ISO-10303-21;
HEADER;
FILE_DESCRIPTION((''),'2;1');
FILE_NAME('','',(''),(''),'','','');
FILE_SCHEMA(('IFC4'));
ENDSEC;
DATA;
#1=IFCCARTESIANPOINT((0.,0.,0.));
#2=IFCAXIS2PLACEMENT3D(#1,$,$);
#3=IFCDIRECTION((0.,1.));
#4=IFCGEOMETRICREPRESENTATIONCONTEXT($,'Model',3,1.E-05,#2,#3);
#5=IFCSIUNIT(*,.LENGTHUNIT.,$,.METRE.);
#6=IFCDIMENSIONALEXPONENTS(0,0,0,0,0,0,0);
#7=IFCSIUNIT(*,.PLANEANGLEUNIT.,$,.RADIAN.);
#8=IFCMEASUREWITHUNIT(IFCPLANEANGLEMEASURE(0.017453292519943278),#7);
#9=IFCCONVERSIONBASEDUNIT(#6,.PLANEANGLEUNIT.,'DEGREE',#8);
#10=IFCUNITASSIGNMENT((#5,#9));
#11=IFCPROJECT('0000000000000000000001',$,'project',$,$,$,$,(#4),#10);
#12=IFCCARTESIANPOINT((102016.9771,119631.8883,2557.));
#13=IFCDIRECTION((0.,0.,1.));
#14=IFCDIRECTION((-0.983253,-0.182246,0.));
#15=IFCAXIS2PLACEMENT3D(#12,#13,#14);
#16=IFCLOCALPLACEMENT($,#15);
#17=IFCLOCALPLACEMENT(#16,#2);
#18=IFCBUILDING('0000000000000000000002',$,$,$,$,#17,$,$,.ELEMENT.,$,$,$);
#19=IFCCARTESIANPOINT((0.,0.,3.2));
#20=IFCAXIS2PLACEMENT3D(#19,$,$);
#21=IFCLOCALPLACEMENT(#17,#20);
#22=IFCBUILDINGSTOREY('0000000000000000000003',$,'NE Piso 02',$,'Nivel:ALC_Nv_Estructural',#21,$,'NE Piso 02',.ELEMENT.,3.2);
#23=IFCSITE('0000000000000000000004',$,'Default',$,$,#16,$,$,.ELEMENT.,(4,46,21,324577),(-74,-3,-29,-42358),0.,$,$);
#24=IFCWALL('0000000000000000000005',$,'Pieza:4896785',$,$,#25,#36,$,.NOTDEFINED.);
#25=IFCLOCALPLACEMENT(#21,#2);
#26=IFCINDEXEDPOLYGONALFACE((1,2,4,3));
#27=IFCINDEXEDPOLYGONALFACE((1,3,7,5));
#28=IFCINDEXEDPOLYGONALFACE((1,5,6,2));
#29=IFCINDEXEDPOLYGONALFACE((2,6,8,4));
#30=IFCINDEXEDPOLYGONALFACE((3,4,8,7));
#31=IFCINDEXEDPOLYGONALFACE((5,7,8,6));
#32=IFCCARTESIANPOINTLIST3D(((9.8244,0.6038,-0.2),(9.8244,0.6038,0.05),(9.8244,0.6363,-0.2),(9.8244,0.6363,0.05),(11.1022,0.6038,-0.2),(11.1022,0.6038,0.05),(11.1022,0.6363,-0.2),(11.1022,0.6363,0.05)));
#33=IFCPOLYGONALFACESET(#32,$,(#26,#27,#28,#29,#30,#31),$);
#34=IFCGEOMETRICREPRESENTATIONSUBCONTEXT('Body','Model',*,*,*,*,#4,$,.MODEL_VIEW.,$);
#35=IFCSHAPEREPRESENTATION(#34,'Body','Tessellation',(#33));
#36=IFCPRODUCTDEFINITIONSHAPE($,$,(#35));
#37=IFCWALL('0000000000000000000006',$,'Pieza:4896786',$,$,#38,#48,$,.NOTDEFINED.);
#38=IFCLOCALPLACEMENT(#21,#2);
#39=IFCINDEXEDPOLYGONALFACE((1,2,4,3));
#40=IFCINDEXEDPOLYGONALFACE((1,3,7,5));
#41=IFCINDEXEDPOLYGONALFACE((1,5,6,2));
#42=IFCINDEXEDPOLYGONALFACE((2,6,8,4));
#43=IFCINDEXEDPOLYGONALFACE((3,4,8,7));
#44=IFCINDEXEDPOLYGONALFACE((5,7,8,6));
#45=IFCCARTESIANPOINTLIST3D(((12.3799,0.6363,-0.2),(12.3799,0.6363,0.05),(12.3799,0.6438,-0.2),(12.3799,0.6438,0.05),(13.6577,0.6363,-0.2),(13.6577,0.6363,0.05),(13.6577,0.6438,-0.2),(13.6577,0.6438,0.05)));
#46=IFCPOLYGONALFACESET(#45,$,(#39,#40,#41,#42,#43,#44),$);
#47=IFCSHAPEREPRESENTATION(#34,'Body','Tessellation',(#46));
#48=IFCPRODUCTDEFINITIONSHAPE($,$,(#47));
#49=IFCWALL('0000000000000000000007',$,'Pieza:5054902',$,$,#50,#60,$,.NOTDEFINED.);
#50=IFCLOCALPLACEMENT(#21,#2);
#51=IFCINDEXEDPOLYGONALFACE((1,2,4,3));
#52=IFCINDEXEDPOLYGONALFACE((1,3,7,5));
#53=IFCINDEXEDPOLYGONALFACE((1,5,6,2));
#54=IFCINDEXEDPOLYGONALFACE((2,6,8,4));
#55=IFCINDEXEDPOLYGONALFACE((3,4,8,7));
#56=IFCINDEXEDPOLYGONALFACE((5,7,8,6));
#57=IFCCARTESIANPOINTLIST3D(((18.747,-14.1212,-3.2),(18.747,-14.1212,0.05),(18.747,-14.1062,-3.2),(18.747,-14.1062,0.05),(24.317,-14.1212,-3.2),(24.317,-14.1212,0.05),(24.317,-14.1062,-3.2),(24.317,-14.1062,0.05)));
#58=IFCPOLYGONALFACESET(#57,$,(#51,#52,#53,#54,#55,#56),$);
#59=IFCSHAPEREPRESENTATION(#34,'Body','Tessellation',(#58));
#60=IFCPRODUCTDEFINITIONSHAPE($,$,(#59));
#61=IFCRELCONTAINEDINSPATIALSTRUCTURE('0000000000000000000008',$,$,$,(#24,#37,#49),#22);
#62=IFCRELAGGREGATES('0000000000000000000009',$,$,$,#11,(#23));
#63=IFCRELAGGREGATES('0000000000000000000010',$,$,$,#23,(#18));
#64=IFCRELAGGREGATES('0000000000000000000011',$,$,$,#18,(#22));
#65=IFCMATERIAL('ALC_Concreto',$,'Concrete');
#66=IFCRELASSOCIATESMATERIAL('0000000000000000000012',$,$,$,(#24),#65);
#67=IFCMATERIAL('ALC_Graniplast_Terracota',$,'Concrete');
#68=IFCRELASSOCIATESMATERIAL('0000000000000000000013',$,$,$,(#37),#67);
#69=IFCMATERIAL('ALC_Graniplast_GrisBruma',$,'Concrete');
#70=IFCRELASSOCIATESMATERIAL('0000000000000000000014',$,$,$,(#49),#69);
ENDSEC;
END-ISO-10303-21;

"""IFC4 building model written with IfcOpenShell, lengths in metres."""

from ifc_helpers import new_model, entity, si_unit, converted_unit, direction, frame, frame_2d, origin, origin_2d_with_axis, place, context, subcontext, project, spatial, rectangle, extrude, material, element, save


model = new_model("IFC4")

# Units and contexts
model_context = context("Model", 3, precision=1e-05, world=origin(), true_north=direction((0.0, 1.0)))
body_context = subcontext(model_context, "Body", "Model", "MODEL_VIEW")
ifc_project = project(units=[si_unit("LENGTHUNIT", "METRE"), converted_unit("PLANEANGLEUNIT", "DEGREE", entity("IfcPlaneAngleMeasure", 0.017453292519943278), si_unit("PLANEANGLEUNIT", "RADIAN"), dimensions=[0, 0, 0, 0, 0, 0, 0])], contexts=[model_context])

# Site, building, storey
site_placement = place(None, frame((102016.9771, 119631.8883, 2557.0), z_axis=(0.0, 0.0, 1.0), x_axis=(-0.983253, -0.182246, 0.0)))
site = spatial("IfcSite", under=ifc_project, at=site_placement, Name="Default", CompositionType="ELEMENT", RefLatitude=(4, 46, 21, 324577), RefLongitude=(-74, -3, -29, -42358), RefElevation=0.0)
building_placement = place(site_placement, origin())
building = spatial("IfcBuilding", under=site, at=building_placement, CompositionType="ELEMENT")
storey_placement = place(building_placement, frame((0.0, 0.0, 3.2)))
storey = spatial("IfcBuildingStorey", under=building, at=storey_placement, Name="NE Piso 02", ObjectType="Nivel:ALC_Nv_Estructural", LongName="NE Piso 02", CompositionType="ELEMENT", Elevation=3.2)

# Walls
ifc_material_1 = material(Name="ALC_Graniplast_Terracota", Category="Concrete")
ifc_material_2 = material(Name="ALC_Concreto", Category="Concrete")
wall_1_placement = place(storey_placement, frame((0.0, 0.0, -0.2)))
element("IfcWall", 1, at=wall_1_placement, inside=storey, material=ifc_material_2, Name="Pieza:4896785", PredefinedType="NOTDEFINED", context=body_context, shape_type="SweptSolid", body=[
    extrude(rectangle(XDim=0.0325, YDim=1.2778, at=frame_2d((0.0, 0.0), x_axis=(1.0, 0.0))), frame((10.4633, 0.6201, 0.0), z_axis=(0.0, 0.0, 1.0), x_axis=(0.0, -1.0, 0.0)), (0.0, 0.0, 1.0), 0.25),
])
wall_2_placement = place(storey_placement, frame((0.0, 0.0, -0.2)))
element("IfcWall", 2, at=wall_2_placement, inside=storey, material=ifc_material_1, Name="Pieza:4896786", PredefinedType="NOTDEFINED", context=body_context, shape_type="SweptSolid", body=[
    extrude(rectangle(XDim=0.0075, YDim=1.2778, at=origin_2d_with_axis()), frame((13.0188, 0.6401, 0.0), z_axis=(0.0, 0.0, 1.0), x_axis=(0.0, -1.0, 0.0)), (0.0, 0.0, 1.0), 0.25),
])
ifc_material_3 = material(Name="ALC_Graniplast_GrisBruma", Category="Concrete")
wall_3_placement = place(storey_placement, frame((0.0, 0.0, -3.2)))
element("IfcWall", 3, at=wall_3_placement, inside=storey, material=ifc_material_3, Name="Pieza:5054902", PredefinedType="NOTDEFINED", context=body_context, shape_type="SweptSolid", body=[
    extrude(rectangle(XDim=0.015, YDim=5.57, at=frame_2d((0.0, 0.0), x_axis=(1.0, 0.0))), frame((21.532, -14.1137, 0.0), z_axis=(0.0, 0.0, 1.0), x_axis=(0.0, -1.0, 0.0)), (0.0, 0.0, 1.0), 3.25),
])

save(model, "model.ifc")
